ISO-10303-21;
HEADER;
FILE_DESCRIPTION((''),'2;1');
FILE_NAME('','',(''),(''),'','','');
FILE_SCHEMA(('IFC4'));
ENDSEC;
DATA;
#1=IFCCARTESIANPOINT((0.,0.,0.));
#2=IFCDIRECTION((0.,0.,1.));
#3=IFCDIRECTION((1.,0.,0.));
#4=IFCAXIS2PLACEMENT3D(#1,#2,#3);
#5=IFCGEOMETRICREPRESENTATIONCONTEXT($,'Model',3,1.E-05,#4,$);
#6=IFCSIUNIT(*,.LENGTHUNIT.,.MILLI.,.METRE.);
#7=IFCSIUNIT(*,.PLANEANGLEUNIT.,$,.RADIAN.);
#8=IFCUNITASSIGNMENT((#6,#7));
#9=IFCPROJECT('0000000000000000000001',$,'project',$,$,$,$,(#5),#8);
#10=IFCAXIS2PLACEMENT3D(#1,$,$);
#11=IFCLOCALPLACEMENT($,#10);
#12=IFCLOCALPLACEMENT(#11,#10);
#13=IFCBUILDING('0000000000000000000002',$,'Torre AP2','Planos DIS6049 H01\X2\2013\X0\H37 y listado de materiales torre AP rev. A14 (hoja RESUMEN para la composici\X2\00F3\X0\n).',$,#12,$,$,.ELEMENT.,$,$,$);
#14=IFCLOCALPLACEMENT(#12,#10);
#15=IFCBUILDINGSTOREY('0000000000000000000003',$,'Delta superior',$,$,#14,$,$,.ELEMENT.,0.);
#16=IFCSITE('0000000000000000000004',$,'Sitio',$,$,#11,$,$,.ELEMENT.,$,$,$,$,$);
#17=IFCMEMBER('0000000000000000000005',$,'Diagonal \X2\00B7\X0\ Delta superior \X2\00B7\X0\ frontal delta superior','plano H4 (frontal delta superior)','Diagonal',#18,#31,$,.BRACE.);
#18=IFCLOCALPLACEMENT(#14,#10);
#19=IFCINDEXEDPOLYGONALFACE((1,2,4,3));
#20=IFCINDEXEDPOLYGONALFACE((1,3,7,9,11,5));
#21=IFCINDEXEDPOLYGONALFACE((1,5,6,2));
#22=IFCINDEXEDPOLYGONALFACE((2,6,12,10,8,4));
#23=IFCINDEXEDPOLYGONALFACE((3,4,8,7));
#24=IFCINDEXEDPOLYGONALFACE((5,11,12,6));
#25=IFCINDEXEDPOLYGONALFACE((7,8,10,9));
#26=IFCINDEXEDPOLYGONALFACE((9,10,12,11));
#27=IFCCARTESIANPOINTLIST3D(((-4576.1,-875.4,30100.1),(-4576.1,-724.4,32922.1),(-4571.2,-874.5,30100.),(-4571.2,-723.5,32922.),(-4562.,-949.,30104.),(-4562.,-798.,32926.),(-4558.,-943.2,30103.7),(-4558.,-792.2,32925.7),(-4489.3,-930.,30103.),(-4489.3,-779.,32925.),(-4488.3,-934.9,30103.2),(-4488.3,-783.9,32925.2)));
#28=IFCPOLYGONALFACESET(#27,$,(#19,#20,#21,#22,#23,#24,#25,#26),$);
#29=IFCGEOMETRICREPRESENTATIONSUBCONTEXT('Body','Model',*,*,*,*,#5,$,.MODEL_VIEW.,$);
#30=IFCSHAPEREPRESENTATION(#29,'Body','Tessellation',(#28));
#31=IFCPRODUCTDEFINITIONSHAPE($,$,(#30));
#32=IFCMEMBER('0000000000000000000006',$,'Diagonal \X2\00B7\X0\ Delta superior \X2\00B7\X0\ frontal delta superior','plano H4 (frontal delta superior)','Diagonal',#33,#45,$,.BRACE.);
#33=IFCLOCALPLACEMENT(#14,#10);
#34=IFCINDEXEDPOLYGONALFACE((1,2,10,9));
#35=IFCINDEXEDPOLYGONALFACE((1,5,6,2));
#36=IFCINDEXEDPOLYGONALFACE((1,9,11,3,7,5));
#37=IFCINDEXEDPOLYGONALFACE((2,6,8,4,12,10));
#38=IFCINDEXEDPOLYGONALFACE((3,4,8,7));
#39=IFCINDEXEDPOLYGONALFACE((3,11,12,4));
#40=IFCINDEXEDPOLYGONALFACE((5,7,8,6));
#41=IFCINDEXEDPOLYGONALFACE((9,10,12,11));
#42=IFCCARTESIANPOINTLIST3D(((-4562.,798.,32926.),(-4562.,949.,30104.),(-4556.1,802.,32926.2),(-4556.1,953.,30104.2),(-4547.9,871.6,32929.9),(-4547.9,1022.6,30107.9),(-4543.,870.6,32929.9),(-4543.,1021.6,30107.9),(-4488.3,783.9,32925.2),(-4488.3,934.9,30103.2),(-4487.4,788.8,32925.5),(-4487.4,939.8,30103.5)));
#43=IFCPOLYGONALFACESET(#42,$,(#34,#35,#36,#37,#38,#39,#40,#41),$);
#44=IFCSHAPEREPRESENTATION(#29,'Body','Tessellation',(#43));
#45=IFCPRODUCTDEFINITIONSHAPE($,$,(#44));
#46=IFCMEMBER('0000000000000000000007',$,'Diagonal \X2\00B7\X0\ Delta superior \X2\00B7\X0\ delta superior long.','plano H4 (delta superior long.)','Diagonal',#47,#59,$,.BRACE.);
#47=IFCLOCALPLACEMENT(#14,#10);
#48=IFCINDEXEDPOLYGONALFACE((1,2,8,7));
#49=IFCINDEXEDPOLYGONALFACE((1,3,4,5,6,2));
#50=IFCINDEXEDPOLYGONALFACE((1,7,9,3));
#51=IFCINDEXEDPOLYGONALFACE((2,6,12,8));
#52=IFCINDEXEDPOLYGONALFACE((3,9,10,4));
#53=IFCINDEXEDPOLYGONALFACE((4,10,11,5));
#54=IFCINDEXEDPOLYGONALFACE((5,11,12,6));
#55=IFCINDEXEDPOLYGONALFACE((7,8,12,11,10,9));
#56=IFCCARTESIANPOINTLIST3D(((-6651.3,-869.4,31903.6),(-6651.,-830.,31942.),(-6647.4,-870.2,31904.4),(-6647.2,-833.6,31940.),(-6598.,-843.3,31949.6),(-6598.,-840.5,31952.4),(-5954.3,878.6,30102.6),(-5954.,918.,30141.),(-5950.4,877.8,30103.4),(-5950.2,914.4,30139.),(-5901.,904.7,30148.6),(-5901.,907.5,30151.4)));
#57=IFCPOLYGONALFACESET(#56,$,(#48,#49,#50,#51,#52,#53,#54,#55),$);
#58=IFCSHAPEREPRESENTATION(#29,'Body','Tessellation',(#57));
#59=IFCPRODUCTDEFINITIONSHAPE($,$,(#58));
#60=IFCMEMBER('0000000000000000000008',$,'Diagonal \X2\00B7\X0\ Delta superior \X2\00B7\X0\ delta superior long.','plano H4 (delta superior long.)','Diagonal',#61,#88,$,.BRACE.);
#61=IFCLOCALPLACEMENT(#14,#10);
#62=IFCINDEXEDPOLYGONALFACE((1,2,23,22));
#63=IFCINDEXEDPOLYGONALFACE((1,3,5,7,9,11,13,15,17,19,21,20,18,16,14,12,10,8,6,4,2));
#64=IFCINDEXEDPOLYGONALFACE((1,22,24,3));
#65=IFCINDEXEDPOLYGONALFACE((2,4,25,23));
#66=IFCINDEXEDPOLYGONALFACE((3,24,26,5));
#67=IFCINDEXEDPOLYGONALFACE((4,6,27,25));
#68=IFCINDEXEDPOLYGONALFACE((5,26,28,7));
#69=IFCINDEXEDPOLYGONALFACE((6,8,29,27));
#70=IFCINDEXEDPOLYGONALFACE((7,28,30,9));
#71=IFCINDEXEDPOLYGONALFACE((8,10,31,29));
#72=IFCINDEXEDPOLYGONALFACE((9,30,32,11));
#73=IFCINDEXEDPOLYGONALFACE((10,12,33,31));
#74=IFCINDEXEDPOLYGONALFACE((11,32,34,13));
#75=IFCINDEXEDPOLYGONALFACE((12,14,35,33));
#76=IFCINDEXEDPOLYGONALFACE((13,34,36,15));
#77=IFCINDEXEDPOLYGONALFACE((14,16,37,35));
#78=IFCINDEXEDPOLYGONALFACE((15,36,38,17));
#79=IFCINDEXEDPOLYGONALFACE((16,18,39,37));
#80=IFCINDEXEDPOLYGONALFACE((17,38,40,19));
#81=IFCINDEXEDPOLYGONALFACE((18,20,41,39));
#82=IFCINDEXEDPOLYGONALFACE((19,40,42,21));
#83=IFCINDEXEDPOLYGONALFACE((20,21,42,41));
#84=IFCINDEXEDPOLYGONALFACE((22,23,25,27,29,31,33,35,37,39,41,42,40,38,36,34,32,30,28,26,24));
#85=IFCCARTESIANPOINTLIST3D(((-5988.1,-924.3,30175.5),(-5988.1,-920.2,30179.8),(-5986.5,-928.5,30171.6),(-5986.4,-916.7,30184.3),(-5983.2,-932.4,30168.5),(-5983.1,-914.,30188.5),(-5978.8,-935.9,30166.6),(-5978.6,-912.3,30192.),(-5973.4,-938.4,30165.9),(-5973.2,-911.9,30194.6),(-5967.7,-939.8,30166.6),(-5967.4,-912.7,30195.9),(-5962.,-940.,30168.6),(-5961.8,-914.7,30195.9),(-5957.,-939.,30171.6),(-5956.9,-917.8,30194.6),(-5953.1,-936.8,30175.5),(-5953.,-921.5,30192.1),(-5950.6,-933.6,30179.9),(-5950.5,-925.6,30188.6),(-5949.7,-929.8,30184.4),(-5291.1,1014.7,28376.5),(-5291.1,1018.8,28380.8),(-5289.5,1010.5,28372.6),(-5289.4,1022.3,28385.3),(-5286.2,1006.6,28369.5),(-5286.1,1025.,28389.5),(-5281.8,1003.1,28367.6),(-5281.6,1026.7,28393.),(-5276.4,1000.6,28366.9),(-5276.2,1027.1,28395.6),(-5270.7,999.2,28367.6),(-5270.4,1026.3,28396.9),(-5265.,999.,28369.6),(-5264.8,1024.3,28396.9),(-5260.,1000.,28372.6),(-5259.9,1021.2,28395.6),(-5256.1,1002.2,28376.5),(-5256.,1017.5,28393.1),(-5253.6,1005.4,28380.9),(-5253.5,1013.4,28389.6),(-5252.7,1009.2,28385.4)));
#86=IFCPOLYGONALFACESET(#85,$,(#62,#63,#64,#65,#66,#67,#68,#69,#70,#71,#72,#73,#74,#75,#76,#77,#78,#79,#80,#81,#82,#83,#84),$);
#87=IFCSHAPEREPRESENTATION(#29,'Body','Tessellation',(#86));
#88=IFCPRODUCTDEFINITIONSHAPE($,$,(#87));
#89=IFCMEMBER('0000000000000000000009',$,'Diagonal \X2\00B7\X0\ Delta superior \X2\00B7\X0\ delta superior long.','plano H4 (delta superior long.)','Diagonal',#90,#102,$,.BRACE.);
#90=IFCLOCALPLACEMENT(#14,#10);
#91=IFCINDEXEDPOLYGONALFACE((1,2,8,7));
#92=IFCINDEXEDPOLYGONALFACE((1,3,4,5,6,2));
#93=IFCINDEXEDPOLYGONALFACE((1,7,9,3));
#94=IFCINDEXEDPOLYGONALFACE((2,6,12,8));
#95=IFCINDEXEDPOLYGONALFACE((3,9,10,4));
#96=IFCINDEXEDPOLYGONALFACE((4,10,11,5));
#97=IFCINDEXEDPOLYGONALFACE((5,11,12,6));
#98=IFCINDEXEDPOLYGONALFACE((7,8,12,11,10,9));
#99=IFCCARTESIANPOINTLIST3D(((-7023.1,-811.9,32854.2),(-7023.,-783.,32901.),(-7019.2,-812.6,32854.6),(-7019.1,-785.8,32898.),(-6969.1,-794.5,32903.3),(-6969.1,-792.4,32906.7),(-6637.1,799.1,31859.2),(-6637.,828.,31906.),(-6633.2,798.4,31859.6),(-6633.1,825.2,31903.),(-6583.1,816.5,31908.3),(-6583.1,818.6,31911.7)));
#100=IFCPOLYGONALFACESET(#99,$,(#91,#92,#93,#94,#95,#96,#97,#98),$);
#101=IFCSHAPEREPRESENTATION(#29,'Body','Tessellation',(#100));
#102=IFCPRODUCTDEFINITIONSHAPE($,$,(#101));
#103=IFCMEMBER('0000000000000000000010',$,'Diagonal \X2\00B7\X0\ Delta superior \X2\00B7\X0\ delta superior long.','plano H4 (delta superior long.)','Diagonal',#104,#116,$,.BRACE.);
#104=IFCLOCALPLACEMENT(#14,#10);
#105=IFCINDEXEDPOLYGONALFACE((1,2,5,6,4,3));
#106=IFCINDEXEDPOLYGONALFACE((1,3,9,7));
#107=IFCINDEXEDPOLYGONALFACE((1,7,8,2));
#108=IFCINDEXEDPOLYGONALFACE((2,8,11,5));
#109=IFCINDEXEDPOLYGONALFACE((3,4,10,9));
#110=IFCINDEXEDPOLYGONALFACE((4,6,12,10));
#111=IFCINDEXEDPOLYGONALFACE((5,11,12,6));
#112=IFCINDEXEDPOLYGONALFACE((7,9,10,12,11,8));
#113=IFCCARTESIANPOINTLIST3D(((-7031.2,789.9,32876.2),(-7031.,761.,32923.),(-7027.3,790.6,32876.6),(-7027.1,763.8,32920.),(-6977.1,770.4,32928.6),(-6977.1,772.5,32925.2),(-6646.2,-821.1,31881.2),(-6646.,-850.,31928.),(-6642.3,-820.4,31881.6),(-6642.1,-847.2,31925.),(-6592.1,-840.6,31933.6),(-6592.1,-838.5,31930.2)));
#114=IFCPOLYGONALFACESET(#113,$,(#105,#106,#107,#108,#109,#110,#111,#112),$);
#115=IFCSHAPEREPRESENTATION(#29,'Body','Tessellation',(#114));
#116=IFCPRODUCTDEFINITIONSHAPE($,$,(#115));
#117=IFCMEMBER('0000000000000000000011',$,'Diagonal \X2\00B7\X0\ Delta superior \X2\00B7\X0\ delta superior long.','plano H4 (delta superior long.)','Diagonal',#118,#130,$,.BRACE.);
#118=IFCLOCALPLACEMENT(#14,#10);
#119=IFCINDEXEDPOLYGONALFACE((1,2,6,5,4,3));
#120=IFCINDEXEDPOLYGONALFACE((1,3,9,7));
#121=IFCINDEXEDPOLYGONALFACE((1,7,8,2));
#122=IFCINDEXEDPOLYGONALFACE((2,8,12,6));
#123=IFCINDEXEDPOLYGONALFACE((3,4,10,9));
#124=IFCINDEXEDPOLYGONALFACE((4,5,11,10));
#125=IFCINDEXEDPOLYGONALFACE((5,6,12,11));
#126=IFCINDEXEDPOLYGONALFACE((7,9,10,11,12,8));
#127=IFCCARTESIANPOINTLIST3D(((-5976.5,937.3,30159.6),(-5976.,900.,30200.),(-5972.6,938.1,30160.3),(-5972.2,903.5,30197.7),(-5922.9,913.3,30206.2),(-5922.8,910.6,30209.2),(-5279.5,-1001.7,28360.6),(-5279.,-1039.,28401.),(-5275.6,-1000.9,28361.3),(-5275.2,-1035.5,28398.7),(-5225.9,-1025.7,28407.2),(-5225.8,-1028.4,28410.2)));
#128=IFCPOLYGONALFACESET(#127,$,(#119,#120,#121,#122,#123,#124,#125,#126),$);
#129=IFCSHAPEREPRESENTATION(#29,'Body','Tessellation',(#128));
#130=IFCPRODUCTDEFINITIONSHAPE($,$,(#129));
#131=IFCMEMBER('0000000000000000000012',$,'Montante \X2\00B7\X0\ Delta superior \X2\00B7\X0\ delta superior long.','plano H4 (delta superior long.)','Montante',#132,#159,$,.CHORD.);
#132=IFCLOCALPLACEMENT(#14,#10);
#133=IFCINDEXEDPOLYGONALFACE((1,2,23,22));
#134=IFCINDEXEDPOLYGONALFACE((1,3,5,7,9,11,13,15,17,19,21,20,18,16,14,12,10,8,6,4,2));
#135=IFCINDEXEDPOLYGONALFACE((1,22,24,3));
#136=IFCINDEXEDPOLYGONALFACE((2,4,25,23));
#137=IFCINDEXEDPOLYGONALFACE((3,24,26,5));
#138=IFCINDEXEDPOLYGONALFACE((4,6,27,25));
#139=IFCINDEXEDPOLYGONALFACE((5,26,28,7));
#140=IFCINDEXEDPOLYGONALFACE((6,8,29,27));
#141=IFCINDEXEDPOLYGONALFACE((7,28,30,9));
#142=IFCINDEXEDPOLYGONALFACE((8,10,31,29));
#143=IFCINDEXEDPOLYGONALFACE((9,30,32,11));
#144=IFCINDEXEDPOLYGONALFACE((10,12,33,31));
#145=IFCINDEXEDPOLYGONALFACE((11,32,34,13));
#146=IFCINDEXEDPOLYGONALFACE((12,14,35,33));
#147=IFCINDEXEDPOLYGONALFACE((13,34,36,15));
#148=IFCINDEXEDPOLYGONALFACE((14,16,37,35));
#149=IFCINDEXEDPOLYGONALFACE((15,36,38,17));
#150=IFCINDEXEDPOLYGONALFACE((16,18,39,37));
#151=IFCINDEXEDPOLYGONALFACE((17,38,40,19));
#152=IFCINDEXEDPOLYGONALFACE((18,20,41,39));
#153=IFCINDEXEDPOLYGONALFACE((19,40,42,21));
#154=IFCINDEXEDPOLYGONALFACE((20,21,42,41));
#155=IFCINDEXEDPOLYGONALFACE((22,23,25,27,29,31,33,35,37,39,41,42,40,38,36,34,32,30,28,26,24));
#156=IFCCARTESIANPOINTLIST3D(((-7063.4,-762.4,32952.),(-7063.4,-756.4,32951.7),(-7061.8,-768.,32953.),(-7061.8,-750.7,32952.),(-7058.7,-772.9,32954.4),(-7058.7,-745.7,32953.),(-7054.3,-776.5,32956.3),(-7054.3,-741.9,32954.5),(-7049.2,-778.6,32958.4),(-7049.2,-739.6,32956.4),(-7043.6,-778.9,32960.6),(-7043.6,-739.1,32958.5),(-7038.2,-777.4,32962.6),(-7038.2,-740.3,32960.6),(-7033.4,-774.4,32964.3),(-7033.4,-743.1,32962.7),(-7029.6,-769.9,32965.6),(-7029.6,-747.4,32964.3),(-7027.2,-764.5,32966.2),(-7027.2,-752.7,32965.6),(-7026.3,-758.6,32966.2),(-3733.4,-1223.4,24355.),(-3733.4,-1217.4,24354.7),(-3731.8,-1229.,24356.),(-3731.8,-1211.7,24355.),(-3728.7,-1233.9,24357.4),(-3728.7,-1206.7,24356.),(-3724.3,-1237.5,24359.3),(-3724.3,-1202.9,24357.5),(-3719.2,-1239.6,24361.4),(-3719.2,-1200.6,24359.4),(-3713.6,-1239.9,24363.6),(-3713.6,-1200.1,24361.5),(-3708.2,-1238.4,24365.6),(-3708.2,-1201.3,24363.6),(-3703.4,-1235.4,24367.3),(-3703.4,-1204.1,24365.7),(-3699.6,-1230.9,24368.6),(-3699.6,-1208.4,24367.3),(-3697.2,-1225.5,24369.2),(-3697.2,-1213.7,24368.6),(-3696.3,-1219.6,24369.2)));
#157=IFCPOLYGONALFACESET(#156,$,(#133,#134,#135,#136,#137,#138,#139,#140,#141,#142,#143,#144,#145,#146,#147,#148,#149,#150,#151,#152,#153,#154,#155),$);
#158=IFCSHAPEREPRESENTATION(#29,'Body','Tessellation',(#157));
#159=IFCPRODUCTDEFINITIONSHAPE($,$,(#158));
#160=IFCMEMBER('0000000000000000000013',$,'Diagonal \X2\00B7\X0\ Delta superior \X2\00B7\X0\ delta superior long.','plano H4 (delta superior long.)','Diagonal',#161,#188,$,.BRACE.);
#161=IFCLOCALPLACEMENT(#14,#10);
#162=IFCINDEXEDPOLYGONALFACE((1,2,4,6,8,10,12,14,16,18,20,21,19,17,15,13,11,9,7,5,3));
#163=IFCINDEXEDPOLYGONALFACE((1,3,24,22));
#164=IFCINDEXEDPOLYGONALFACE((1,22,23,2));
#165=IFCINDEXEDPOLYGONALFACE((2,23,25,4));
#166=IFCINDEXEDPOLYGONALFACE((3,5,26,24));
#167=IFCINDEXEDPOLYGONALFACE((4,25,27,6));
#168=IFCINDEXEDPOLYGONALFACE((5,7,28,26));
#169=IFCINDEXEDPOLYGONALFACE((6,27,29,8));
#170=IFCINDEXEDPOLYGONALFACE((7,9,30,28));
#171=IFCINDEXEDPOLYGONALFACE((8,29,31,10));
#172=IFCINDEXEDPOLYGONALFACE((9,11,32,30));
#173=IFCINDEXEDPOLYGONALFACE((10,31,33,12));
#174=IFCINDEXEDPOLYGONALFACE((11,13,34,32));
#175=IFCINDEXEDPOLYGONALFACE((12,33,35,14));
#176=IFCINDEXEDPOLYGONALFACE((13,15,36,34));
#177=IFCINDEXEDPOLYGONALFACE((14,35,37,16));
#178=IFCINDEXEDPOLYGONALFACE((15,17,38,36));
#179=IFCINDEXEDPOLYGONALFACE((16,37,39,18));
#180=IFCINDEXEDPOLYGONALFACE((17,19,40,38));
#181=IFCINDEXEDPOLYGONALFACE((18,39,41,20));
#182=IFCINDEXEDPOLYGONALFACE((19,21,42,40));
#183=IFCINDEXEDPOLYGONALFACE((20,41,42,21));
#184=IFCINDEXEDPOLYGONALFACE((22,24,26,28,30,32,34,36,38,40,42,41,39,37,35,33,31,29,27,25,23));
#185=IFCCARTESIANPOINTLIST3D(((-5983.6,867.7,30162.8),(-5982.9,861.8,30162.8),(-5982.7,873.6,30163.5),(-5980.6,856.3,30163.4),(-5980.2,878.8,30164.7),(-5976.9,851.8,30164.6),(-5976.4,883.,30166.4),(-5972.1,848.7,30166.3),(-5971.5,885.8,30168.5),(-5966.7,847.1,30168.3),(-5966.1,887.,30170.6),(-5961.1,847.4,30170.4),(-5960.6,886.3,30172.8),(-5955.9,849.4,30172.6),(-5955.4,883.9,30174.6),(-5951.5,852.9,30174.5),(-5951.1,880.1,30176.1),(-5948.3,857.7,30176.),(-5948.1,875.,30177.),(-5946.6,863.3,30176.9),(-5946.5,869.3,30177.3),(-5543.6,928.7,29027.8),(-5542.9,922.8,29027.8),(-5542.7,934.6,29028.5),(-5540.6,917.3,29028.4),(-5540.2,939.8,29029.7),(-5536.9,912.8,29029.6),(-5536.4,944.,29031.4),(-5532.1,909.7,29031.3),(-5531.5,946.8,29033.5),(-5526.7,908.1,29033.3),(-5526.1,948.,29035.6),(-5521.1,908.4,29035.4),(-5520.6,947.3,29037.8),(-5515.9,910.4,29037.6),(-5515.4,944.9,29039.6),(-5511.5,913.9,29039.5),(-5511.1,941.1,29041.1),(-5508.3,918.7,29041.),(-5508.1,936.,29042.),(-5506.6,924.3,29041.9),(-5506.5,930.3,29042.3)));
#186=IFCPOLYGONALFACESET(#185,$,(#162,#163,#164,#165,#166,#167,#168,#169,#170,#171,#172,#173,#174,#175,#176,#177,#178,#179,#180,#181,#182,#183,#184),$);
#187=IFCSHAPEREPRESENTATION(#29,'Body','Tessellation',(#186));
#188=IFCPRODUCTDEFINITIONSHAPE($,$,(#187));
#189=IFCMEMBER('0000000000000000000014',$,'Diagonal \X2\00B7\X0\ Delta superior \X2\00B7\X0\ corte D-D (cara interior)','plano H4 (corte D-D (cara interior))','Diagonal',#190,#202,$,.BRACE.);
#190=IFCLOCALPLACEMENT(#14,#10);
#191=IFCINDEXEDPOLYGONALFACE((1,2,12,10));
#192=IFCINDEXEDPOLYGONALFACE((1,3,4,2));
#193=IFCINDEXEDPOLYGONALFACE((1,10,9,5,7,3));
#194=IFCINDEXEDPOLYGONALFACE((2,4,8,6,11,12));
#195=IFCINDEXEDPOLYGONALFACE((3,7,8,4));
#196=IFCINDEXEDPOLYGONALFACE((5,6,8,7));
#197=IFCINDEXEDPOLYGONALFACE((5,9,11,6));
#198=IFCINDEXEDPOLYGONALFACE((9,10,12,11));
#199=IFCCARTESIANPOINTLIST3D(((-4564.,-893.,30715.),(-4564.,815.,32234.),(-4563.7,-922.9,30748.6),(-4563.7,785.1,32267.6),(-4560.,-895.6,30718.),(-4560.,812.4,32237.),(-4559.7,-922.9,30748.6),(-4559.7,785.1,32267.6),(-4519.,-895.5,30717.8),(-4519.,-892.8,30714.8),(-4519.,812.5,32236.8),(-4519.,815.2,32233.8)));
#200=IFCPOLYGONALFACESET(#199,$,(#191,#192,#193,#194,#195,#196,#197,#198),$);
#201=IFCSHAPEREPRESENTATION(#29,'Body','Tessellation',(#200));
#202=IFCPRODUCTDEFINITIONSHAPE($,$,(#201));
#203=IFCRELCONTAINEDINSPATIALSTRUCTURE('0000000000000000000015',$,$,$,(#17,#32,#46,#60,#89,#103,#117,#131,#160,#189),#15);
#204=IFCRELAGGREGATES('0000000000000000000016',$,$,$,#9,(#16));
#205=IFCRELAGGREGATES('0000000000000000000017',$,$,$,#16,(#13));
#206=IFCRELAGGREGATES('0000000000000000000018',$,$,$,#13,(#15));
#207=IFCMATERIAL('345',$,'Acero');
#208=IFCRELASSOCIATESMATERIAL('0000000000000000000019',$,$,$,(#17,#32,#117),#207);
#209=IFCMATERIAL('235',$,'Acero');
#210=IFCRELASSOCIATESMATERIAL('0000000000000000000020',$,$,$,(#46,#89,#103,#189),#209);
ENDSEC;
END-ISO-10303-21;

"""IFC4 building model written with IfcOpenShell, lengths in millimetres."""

from ifc_helpers import new_model, si_unit, frame, frame_2d, origin, origin_with_axes, place, context, subcontext, project, spatial, circle, l_section, extrude, material, element, save


model = new_model("IFC4")

# Units and contexts
model_context = context("Model", 3, precision=1e-05, world=origin_with_axes())
body_context = subcontext(model_context, "Body", "Model", "MODEL_VIEW")
ifc_project = project(units=[si_unit("LENGTHUNIT", "METRE", prefix="MILLI"), si_unit("PLANEANGLEUNIT", "RADIAN")], contexts=[model_context])

# Site, building, storey
site_placement = place(None, origin())
site = spatial("IfcSite", under=ifc_project, at=site_placement, Name="Sitio", CompositionType="ELEMENT")
building_placement = place(site_placement, origin())
building = spatial("IfcBuilding", under=site, at=building_placement, Name="Torre AP2", Description="Planos DIS6049 H01–H37 y listado de materiales torre AP rev. A14 (hoja RESUMEN para la composición).", CompositionType="ELEMENT")
storey_placement = place(building_placement, origin())
storey = spatial("IfcBuildingStorey", under=building, at=storey_placement, Name="Delta superior", CompositionType="ELEMENT", Elevation=0.0)

# Members
ifc_material_1 = material(Name="235", Category="Acero")
ifc_material_2 = material(Name="345", Category="Acero")
for number, where, z_axis, x_axis, name in (
    (1, (-4562.0, -949.0, 30104.0), (0.0, 0.053432, 0.998572), (0.982208, 0.187529, -0.010034), "Diagonal · Delta superior · frontal delta superior"),
    (2, (-4562.0, 949.0, 30104.0), (0.0, -0.053432, 0.998572), (0.982208, -0.187529, -0.010034), "Diagonal · Delta superior · frontal delta superior"),
):
    element("IfcMember", number, at=place(storey_placement, frame(where, z_axis=z_axis, x_axis=x_axis)), inside=storey, material=ifc_material_2, Name=name, Description="plano H4 (frontal delta superior)", ObjectType="Diagonal", PredefinedType="BRACE", context=body_context, shape_type="SweptSolid", body=[
        extrude(l_section(Depth=75.0, Width=75.0, Thickness=5.0, at=frame_2d((37.5, 37.5))), None, (0.0, 0.0, 1.0), 2826.0),
    ])
member_1_placement = place(storey_placement, frame((-6651.0, -830.0, 31942.0), z_axis=(0.267584, 0.671072, -0.691419), x_axis=(0.963521, -0.190088, 0.188396)))
element("IfcMember", 3, at=member_1_placement, inside=storey, material=ifc_material_1, Name="Diagonal · Delta superior · delta superior long.", Description="plano H4 (delta superior long.)", ObjectType="Diagonal", PredefinedType="BRACE", context=body_context, shape_type="SweptSolid", body=[
    extrude(l_section(Depth=55.0, Width=55.0, Thickness=4.0, at=frame_2d((27.5, 27.5))), None, (0.0, 0.0, 1.0), 2604.8),
])
member_2_placement = place(storey_placement, frame((-5969.0, -926.0, 30181.0), z_axis=(0.254816, 0.708877, -0.657695), x_axis=(0.966975, -0.190493, 0.169325)))
element("IfcMember", 4, at=member_2_placement, inside=storey, Name="Diagonal · Delta superior · delta superior long.", Description="plano H4 (delta superior long.)", ObjectType="Diagonal", PredefinedType="BRACE", context=body_context, shape_type="SweptSolid", body=[
    extrude(circle(Radius=20.0), None, (0.0, 0.0, 1.0), 2735.3),
])
member_3_placement = place(storey_placement, frame((-7023.0, -783.0, 32901.0), z_axis=(0.199747, 0.833659, -0.514892), x_axis=(0.979846, -0.170873, 0.103461)))
element("IfcMember", 5, at=member_3_placement, inside=storey, material=ifc_material_1, Name="Diagonal · Delta superior · delta superior long.", Description="plano H4 (delta superior long.)", ObjectType="Diagonal", PredefinedType="BRACE", context=body_context, shape_type="SweptSolid", body=[
    extrude(l_section(Depth=55.0, Width=55.0, Thickness=4.0, at=frame_2d((27.5, 27.5))), None, (0.0, 0.0, 1.0), 1932.4),
])
member_4_placement = place(storey_placement, frame((-6646.0, -850.0, 31928.0), z_axis=(-0.19925, 0.833745, 0.514945), x_axis=(0.979943, 0.171353, 0.101736)))
element("IfcMember", 6, at=member_4_placement, inside=storey, material=ifc_material_1, Name="Diagonal · Delta superior · delta superior long.", Description="plano H4 (delta superior long.)", ObjectType="Diagonal", PredefinedType="BRACE", context=body_context, shape_type="SweptSolid", body=[
    extrude(l_section(Depth=55.0, Width=55.0, Thickness=4.0, at=frame_2d((27.5, 27.5))), None, (0.0, 0.0, 1.0), 1932.2),
])
member_5_placement = place(storey_placement, frame((-5279.0, -1039.0, 28401.0), z_axis=(-0.254816, 0.708877, 0.657695), x_axis=(0.966953, 0.192686, 0.166953)))
element("IfcMember", 7, at=member_5_placement, inside=storey, material=ifc_material_2, Name="Diagonal · Delta superior · delta superior long.", Description="plano H4 (delta superior long.)", ObjectType="Diagonal", PredefinedType="BRACE", context=body_context, shape_type="SweptSolid", body=[
    extrude(l_section(Depth=55.0, Width=55.0, Thickness=4.0, at=frame_2d((27.5, 27.5))), None, (0.0, 0.0, 1.0), 2735.3),
])
for number, where, z_axis, x_axis, name in (
    (8, (-3715.0, -1220.0, 24362.0), (-0.360744, 0.049941, 0.931327), (0.932665, 0.019317, 0.360227), "Montante · Delta superior · delta superior long."),
):
    element("IfcMember", number, at=place(storey_placement, frame(where, z_axis=z_axis, x_axis=x_axis)), inside=storey, Name=name, Description="plano H4 (delta superior long.)", ObjectType="Montante", PredefinedType="CHORD", context=body_context, shape_type="SweptSolid", body=[
        extrude(circle(Radius=20.0), None, (0.0, 0.0, 1.0), 9230.9),
    ])
member_6_placement = place(storey_placement, frame((-5525.0, 928.0, 29035.0), z_axis=(-0.361002, -0.050048, 0.931221), x_axis=(0.919866, -0.183339, 0.346747)))
element("IfcMember", 9, at=member_6_placement, inside=storey, Name="Diagonal · Delta superior · delta superior long.", Description="plano H4 (delta superior long.)", ObjectType="Diagonal", PredefinedType="BRACE", context=body_context, shape_type="SweptSolid", body=[
    extrude(circle(Radius=20.0), None, (0.0, 0.0, 1.0), 1218.8),
])
member_7_placement = place(storey_placement, frame((-4564.0, 815.0, 32234.0), z_axis=(0.0, -0.74724, -0.664554), x_axis=(0.999984, 0.003774, -0.004243)))
element("IfcMember", 10, at=member_7_placement, inside=storey, material=ifc_material_1, Name="Diagonal · Delta superior · corte D-D (cara interior)", Description="plano H4 (corte D-D (cara interior))", ObjectType="Diagonal", PredefinedType="BRACE", context=body_context, shape_type="SweptSolid", body=[
    extrude(l_section(Depth=45.0, Width=45.0, Thickness=4.0, at=frame_2d((22.5, 22.5))), None, (0.0, 0.0, 1.0), 2285.7),
])

save(model, "model.ifc")
